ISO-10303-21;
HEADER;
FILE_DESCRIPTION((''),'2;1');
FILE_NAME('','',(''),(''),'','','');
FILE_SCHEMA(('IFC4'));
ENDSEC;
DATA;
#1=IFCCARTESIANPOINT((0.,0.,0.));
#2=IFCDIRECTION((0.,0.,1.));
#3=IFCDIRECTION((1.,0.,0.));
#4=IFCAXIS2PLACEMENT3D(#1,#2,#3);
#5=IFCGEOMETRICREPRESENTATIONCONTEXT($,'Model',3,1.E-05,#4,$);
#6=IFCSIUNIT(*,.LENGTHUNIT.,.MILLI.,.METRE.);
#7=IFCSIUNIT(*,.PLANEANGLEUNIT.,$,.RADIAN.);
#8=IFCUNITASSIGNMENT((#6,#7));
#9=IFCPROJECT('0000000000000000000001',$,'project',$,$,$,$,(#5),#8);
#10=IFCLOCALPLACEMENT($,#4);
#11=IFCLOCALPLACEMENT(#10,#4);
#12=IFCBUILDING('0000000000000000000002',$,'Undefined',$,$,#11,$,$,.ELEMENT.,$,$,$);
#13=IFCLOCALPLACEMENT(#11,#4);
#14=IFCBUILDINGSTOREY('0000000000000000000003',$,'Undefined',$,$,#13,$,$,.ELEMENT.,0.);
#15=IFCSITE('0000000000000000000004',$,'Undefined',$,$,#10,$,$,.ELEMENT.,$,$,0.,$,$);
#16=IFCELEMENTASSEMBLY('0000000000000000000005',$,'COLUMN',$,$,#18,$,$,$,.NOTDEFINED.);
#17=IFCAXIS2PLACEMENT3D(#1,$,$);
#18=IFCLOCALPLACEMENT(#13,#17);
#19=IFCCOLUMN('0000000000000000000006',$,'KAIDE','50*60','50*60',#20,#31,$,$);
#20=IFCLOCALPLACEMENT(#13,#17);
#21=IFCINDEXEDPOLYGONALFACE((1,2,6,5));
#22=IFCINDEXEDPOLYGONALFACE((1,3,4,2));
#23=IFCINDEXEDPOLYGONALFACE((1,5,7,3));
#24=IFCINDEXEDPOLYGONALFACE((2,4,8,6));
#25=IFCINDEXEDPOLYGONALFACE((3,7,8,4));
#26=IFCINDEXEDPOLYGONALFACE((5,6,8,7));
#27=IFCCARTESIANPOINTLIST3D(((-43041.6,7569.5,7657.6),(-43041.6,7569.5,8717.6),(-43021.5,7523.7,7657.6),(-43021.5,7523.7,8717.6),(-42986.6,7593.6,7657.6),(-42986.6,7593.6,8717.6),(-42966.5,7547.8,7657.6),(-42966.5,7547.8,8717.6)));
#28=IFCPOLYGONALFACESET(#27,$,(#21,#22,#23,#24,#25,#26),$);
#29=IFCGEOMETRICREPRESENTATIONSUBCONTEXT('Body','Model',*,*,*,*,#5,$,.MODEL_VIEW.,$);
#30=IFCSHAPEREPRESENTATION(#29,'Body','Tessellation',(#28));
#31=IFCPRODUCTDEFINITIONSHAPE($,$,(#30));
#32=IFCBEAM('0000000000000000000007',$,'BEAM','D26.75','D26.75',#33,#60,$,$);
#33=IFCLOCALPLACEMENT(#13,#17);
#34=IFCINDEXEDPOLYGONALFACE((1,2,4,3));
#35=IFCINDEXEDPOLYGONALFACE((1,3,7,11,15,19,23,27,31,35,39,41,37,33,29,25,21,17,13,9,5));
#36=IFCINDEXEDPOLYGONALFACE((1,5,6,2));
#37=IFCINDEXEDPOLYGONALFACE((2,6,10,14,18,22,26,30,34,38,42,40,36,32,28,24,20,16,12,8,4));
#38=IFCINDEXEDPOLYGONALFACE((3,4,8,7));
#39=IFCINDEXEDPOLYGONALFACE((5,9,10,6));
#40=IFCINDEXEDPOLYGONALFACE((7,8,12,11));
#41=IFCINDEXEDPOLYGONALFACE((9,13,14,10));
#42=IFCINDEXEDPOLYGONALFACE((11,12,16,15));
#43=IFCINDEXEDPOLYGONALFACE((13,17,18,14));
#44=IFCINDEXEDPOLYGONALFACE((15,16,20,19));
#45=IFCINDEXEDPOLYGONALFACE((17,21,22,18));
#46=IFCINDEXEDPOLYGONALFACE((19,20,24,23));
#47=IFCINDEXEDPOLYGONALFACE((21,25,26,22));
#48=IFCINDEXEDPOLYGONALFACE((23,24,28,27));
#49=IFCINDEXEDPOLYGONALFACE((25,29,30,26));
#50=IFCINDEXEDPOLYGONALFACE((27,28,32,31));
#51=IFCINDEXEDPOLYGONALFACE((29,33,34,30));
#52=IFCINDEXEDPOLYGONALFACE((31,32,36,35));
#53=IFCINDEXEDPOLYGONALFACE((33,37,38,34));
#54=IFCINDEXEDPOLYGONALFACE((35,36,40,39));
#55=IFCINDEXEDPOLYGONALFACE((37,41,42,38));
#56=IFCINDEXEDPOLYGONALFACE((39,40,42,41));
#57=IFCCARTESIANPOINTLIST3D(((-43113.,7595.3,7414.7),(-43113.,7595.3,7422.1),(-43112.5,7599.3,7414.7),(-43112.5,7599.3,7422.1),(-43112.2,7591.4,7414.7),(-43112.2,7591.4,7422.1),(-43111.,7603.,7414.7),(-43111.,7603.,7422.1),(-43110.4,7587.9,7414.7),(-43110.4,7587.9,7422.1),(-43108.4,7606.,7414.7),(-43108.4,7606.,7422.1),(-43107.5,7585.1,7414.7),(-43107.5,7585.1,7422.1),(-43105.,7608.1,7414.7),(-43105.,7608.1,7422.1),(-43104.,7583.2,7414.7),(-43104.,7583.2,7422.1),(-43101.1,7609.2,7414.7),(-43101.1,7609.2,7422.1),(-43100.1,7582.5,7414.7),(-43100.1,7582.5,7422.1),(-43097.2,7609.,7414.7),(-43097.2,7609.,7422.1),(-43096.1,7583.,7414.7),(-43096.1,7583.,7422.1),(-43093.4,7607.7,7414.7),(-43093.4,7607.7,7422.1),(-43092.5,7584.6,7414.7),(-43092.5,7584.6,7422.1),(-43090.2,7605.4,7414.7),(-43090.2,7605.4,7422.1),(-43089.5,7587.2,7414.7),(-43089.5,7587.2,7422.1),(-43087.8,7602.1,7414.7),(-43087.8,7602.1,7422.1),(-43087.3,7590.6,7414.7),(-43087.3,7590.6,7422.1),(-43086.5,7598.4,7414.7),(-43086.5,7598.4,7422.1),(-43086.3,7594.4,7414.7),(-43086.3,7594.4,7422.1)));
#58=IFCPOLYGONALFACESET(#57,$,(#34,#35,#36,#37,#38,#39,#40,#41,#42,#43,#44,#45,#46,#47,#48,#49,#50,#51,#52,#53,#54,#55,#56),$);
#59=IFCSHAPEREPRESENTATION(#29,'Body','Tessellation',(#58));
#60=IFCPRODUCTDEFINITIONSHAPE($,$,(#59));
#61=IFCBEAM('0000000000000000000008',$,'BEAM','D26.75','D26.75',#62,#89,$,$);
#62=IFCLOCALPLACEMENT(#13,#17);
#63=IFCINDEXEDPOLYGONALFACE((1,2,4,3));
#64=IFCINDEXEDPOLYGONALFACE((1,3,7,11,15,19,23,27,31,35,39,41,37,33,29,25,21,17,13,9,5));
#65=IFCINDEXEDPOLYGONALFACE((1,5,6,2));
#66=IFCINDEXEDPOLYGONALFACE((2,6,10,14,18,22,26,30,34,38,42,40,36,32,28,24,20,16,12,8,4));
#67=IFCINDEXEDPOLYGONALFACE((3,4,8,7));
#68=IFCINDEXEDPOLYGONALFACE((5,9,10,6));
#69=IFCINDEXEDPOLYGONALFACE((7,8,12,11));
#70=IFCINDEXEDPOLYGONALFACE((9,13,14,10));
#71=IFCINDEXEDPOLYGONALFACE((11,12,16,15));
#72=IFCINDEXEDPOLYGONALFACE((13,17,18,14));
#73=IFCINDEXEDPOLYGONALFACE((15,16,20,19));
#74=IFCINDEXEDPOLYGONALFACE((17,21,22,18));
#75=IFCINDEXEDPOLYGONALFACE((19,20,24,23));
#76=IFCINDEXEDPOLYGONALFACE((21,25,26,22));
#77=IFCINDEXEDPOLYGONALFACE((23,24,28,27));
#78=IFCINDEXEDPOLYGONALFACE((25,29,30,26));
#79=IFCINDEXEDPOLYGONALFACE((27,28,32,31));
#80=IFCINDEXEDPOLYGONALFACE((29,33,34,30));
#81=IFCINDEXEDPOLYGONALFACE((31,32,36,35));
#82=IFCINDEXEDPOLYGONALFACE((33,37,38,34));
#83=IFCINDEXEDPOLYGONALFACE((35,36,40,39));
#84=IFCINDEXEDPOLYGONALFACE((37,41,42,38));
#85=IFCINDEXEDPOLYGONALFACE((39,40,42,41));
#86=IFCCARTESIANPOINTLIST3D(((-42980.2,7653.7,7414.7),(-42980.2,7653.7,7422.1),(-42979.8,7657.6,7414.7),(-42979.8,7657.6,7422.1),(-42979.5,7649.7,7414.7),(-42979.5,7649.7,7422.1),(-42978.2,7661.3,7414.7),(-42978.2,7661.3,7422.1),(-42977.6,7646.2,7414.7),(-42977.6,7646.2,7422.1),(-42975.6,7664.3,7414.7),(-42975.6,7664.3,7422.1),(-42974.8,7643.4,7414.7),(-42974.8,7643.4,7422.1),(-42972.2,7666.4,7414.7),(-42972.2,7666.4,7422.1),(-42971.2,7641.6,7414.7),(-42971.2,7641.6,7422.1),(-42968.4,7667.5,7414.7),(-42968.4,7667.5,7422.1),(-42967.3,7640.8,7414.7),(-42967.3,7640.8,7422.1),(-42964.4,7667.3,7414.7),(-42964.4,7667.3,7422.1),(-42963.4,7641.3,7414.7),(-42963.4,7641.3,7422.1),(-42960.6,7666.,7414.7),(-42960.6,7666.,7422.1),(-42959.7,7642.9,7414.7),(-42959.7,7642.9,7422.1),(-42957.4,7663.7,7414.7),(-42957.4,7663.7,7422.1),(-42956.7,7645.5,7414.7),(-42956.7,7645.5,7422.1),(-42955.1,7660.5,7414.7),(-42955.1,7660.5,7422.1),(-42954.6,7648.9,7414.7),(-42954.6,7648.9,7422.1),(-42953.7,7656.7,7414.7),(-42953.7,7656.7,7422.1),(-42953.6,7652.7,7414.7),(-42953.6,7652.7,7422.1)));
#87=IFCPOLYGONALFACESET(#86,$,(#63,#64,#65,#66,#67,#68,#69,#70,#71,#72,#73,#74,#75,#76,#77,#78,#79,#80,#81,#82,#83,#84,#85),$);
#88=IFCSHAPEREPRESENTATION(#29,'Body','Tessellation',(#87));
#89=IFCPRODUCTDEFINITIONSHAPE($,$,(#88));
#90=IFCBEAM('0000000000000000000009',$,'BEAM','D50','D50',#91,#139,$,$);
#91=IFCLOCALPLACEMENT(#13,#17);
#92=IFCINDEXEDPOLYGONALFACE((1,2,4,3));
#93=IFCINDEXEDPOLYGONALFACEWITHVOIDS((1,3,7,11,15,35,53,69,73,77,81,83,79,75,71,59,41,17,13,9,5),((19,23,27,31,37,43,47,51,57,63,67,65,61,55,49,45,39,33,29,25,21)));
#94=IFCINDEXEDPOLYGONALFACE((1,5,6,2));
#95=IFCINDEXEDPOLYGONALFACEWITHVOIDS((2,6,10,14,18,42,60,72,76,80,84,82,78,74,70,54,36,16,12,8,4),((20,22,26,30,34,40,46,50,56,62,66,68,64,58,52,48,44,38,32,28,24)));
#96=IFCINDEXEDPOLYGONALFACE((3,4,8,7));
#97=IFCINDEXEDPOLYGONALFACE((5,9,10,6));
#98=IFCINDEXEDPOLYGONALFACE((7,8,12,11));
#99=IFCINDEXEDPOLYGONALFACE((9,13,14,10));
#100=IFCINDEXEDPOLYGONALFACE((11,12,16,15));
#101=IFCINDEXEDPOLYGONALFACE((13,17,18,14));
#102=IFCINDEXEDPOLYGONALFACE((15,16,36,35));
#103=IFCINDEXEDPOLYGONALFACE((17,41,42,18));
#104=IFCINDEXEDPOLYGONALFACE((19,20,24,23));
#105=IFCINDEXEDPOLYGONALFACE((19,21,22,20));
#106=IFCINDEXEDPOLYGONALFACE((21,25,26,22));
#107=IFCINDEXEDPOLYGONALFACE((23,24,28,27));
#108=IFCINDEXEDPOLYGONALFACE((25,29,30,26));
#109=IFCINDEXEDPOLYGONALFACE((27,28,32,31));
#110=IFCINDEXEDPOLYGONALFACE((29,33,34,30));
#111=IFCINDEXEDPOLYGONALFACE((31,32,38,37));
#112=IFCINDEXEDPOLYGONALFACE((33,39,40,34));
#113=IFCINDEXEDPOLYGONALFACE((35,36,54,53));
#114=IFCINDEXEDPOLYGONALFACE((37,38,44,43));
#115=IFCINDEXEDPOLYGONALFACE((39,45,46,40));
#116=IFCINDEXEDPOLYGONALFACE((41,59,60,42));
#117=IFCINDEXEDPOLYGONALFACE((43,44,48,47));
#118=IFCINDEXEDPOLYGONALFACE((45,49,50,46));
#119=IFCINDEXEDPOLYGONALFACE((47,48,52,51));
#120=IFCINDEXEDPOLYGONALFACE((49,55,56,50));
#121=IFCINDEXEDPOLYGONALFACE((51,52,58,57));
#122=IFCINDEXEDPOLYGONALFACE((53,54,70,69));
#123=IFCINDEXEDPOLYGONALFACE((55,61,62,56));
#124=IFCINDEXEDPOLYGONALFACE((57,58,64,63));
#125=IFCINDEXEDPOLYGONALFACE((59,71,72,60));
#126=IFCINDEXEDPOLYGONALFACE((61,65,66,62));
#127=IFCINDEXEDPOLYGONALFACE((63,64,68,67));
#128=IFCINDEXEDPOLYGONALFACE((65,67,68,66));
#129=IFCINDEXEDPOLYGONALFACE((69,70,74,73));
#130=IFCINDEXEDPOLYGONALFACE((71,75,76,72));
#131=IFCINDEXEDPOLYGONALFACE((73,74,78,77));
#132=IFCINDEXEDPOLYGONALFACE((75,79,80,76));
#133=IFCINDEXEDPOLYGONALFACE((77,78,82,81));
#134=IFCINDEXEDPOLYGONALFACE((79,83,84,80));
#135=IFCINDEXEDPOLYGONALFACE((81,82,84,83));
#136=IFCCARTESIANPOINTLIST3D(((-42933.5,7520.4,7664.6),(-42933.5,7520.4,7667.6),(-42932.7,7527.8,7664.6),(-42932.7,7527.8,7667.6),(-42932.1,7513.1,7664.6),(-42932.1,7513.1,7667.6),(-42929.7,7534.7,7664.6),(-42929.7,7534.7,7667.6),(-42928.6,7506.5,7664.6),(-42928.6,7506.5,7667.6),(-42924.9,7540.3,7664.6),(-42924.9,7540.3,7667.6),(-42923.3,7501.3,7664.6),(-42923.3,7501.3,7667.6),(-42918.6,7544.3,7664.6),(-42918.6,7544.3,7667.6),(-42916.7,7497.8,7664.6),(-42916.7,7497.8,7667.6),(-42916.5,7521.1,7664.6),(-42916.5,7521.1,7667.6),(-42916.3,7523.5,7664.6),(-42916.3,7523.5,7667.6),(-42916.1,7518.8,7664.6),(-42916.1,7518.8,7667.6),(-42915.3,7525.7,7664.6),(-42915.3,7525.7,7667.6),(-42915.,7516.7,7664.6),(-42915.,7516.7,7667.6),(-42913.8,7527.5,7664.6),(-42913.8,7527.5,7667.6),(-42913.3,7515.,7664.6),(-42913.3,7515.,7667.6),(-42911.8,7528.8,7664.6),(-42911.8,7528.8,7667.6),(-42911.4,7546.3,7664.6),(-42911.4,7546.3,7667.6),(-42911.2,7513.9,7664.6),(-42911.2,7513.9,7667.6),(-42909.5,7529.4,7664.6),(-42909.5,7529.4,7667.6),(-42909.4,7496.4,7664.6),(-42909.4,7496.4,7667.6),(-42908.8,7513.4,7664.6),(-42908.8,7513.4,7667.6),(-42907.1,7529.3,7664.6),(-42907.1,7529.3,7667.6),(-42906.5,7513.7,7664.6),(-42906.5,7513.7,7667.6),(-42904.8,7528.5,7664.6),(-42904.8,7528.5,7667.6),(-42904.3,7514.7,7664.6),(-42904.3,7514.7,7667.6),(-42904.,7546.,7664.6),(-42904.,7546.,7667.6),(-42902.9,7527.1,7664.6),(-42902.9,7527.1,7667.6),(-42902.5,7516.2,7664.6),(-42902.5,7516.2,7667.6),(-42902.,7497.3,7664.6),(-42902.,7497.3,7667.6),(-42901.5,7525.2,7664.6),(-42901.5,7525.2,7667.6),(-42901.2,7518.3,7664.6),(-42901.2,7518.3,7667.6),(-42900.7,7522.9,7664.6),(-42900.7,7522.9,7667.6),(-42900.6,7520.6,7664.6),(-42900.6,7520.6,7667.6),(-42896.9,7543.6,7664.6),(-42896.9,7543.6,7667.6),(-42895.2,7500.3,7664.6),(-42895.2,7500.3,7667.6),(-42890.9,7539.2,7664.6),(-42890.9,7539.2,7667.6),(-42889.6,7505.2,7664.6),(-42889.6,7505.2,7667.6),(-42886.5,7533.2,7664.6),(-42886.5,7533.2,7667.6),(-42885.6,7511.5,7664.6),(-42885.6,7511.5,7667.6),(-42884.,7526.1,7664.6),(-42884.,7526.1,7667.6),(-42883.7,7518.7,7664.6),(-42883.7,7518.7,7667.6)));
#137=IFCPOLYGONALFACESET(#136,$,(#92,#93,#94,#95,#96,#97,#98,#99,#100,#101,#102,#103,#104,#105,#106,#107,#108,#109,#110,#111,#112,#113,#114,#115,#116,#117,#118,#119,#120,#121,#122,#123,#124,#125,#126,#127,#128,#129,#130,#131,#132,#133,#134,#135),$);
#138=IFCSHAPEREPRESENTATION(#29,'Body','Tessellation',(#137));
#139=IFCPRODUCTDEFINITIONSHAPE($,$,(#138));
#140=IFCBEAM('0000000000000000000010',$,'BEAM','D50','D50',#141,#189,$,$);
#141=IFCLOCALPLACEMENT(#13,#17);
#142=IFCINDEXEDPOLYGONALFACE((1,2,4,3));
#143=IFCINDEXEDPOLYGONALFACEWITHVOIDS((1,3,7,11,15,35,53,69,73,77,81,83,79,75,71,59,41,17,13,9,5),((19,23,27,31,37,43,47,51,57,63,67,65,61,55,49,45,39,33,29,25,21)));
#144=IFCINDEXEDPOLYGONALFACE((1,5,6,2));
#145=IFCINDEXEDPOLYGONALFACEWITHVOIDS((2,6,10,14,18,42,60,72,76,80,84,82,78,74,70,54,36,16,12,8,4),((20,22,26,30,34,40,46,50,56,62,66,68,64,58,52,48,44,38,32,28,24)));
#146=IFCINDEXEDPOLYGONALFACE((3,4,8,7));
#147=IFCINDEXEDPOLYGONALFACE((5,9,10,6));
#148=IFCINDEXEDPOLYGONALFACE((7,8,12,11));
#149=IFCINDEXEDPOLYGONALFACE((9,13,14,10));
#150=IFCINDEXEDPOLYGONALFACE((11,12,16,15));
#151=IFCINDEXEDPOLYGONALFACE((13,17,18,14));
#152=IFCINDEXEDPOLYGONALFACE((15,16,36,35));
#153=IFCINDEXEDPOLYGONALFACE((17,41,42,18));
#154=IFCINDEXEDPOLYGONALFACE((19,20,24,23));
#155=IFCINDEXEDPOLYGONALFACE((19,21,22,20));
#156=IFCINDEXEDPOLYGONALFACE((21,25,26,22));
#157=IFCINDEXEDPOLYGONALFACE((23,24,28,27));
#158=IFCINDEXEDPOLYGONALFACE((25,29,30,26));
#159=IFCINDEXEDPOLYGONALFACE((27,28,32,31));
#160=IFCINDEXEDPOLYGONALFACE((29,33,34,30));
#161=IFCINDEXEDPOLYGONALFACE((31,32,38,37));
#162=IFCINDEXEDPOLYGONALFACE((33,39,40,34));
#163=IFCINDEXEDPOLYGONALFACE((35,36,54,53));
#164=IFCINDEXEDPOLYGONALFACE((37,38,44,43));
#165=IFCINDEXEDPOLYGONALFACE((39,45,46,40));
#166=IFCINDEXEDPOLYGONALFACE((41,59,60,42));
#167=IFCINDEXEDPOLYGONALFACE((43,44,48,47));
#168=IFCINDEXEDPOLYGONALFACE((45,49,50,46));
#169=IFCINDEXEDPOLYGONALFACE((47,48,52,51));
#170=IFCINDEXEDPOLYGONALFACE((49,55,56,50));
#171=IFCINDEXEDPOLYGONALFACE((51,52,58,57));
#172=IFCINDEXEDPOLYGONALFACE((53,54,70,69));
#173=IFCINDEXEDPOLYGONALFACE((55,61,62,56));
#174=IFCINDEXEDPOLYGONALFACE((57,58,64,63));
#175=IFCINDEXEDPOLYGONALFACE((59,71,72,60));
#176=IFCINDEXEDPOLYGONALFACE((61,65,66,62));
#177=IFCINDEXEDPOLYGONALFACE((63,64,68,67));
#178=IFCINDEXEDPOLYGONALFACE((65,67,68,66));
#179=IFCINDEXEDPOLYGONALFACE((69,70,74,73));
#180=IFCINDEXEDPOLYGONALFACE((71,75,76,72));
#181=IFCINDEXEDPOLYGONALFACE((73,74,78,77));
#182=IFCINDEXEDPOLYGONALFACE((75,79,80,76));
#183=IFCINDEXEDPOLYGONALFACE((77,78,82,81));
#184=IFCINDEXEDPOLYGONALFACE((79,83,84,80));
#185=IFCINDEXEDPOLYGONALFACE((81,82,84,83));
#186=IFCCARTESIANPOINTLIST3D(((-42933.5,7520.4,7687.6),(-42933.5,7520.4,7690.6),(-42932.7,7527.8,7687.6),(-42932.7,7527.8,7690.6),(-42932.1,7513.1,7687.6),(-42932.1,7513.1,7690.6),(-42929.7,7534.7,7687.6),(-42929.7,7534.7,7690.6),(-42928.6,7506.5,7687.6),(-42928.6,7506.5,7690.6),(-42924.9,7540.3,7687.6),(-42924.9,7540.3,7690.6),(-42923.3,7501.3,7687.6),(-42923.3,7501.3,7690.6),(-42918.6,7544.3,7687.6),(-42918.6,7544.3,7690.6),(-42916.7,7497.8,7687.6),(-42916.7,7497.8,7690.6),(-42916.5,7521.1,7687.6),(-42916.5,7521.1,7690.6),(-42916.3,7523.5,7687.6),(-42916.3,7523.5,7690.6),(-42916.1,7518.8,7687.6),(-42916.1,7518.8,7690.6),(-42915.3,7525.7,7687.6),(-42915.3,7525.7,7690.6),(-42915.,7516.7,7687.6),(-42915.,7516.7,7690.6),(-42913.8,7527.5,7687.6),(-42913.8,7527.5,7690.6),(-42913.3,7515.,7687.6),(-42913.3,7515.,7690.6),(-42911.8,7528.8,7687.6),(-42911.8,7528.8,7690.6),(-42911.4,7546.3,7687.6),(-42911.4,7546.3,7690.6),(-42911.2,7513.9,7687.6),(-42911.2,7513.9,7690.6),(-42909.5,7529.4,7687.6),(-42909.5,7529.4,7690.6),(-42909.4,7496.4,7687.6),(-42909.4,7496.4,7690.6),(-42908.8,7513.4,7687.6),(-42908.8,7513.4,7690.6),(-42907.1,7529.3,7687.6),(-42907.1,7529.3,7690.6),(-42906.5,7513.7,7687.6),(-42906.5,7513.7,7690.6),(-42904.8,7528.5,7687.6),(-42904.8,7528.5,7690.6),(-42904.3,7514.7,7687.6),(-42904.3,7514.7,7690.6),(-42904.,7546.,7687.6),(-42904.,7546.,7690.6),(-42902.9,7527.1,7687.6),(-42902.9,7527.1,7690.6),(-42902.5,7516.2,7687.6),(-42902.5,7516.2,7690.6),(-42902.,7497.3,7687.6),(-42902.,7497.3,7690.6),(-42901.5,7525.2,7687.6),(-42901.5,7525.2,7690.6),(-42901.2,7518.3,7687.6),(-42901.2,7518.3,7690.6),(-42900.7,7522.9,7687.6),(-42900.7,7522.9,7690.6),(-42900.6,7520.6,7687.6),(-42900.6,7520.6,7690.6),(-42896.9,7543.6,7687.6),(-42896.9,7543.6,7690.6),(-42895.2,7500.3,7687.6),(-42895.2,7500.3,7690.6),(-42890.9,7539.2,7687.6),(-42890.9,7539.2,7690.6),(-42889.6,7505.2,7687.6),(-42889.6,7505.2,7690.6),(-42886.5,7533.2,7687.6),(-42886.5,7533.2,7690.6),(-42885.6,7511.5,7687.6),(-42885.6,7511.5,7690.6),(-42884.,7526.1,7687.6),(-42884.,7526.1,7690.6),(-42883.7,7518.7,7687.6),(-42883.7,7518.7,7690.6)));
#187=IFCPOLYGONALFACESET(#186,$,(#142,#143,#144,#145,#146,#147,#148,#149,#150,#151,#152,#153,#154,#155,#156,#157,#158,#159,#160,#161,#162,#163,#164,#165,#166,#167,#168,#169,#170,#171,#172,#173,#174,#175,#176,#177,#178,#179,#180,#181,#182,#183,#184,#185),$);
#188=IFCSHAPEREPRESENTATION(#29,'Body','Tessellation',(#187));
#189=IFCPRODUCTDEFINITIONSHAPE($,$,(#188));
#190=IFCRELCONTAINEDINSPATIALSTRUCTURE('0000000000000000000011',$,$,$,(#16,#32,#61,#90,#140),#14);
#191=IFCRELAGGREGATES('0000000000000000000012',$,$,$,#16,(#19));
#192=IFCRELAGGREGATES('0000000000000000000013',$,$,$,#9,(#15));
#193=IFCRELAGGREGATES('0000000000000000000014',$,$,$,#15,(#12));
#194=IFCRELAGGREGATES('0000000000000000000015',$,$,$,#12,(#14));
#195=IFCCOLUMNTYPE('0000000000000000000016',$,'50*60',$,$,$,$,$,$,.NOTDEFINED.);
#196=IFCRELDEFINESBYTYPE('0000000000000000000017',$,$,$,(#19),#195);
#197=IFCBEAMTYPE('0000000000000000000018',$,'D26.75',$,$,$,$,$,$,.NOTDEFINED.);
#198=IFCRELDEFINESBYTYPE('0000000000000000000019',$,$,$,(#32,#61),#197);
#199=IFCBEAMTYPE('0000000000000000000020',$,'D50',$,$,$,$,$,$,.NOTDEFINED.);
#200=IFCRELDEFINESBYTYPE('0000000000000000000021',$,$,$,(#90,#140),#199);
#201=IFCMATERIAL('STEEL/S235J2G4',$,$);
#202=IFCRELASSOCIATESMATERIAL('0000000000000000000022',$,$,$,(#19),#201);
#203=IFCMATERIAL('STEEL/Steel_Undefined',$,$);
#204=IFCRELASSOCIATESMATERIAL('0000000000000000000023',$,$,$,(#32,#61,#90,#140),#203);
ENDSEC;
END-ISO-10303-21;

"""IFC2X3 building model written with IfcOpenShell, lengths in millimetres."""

from ifc_helpers import new_model, si_unit, frame, origin_with_axes, origin_2d_with_axis, place, context, subcontext, project, spatial, rectangle, circle, extrude, material, type_object, element, aggregate, save


model = new_model("IFC2X3")

# Units and contexts
model_context = context("Model", 3, precision=1e-05, world=origin_with_axes())
body_context = subcontext(model_context, "Body", "Model", "MODEL_VIEW")
ifc_project = project(units=[si_unit("LENGTHUNIT", "METRE", prefix="MILLI"), si_unit("PLANEANGLEUNIT", "RADIAN")], contexts=[model_context])

# Site, building, storey
site_placement = place(None, origin_with_axes())
site = spatial("IfcSite", under=ifc_project, at=site_placement, Name="Undefined", CompositionType="ELEMENT", RefElevation=0.0)
building_placement = place(site_placement, origin_with_axes())
building = spatial("IfcBuilding", under=site, at=building_placement, Name="Undefined", CompositionType="ELEMENT")
storey_placement = place(building_placement, origin_with_axes())
storey = spatial("IfcBuildingStorey", under=building, at=storey_placement, Name="Undefined", CompositionType="ELEMENT", Elevation=0.0)

# Element assembly, column
assembly_placement = place(storey_placement, frame((-43004.0, 7558.7, 7657.6), z_axis=(-0.402198, 0.915553, 0.0), x_axis=(0.0, 0.0, 1.0)))
assembly = element("IfcElementAssembly", 1, at=assembly_placement, inside=storey, Name="COLUMN", PredefinedType="NOTDEFINED")
ifc_material_1 = material(Name="STEEL/S235J2G4")
column_type = type_object("IfcColumnType", Name="50*60", PredefinedType="NOTDEFINED")
column_placement = place(storey_placement, frame((-43004.0, 7558.7, 7657.6), z_axis=(0.0, 0.0, 1.0), x_axis=(1.0, 0.0, 0.0)))
column = element("IfcColumn", 2, at=column_placement, type_object=column_type, material=ifc_material_1, Name="KAIDE", Description="50*60", ObjectType="50*60", context=body_context, shape_type="SweptSolid", body=[
    extrude(rectangle(XDim=60.0, YDim=50.0, at=origin_2d_with_axis()), frame((0.0, 0.0, 1060.0), z_axis=(0.0, 0.0, -1.0), x_axis=(-0.915553, -0.402197, 0.0)), (0.0, 0.0, 1.0), 1060.0),
])
aggregate(assembly, [column])

# Shared definitions
ifc_material_2 = material(Name="STEEL/Steel_Undefined")
beam_type_1 = type_object("IfcBeamType", Name="D26.75", PredefinedType="NOTDEFINED")

# Beam
beam_1_placement = place(storey_placement, frame((-43099.6, 7595.9, 7422.1), z_axis=(-0.915553, -0.402198, 0.0), x_axis=(0.0, 0.0, -1.0)))
element("IfcBeam", 3, at=beam_1_placement, inside=storey, type_object=beam_type_1, material=ifc_material_2, Name="BEAM", Description="D26.75", ObjectType="D26.75", context=body_context, shape_type="SweptSolid", body=[
    extrude(circle(Radius=13.4, at=origin_2d_with_axis()), frame((7.4, 0.0, 0.0), z_axis=(-1.0, 0.0, 0.0), x_axis=(0.0, -1.0, 0.0)), (0.0, 0.0, 1.0), 7.4),
])

# Beam
beam_2_placement = place(storey_placement, frame((-42966.9, 7654.2, 7422.1), z_axis=(-0.915553, -0.402198, 0.0), x_axis=(0.0, 0.0, -1.0)))
element("IfcBeam", 4, at=beam_2_placement, inside=storey, type_object=beam_type_1, material=ifc_material_2, Name="BEAM", Description="D26.75", ObjectType="D26.75", context=body_context, shape_type="SweptSolid", body=[
    extrude(circle(Radius=13.4, at=origin_2d_with_axis()), frame((7.4, 0.0, 0.0), z_axis=(-1.0, 0.0, 0.0), x_axis=(0.0, -1.0, 0.0)), (0.0, 0.0, 1.0), 7.4),
])

# Beams, openings
beam_type_2 = type_object("IfcBeamType", Name="D50", PredefinedType="NOTDEFINED")
beam_3_placement = place(storey_placement, frame((-42908.5, 7521.4, 7667.6), z_axis=(-0.915553, -0.402198, 0.0), x_axis=(0.0, 0.0, -1.0)))
beam_3 = element("IfcBeam", 5, at=beam_3_placement, inside=storey, type_object=beam_type_2, material=ifc_material_2, Name="BEAM", Description="D50", ObjectType="D50", context=body_context, shape_type="SweptSolid", body=[
    extrude(circle(Radius=25.0, at=origin_2d_with_axis()), frame((3.0, 0.0, 0.0), z_axis=(-1.0, 0.0, 0.0), x_axis=(0.0, -1.0, 0.0)), (0.0, 0.0, 1.0), 3.0),
])
opening_1_placement = place(storey_placement, frame((-42908.5, 7521.4, 7667.6), z_axis=(-0.915553, -0.402198, 0.0), x_axis=(0.0, 0.0, -1.0)))
element("IfcOpeningElement", 6, at=opening_1_placement, cuts=beam_3, ObjectType="Recess", context=body_context, shape_type="SweptSolid", body=[
    extrude(circle(Radius=8.0, at=origin_2d_with_axis()), frame((245.5, 0.0, 0.0), z_axis=(-1.0, 0.0, 0.0), x_axis=(0.0, -1.0, 0.0)), (0.0, 0.0, 1.0), 292.6),
])
beam_4_placement = place(storey_placement, frame((-42908.5, 7521.4, 7690.6), z_axis=(-0.915553, -0.402198, 0.0), x_axis=(0.0, 0.0, -1.0)))
beam_4 = element("IfcBeam", 7, at=beam_4_placement, inside=storey, type_object=beam_type_2, material=ifc_material_2, Name="BEAM", Description="D50", ObjectType="D50", context=body_context, shape_type="SweptSolid", body=[
    extrude(circle(Radius=25.0, at=origin_2d_with_axis()), frame((3.0, 0.0, 0.0), z_axis=(-1.0, 0.0, 0.0), x_axis=(0.0, -1.0, 0.0)), (0.0, 0.0, 1.0), 3.0),
])
opening_2_placement = place(storey_placement, frame((-42908.5, 7521.4, 7690.6), z_axis=(-0.915553, -0.402198, 0.0), x_axis=(0.0, 0.0, -1.0)))
element("IfcOpeningElement", 8, at=opening_2_placement, cuts=beam_4, ObjectType="Recess", context=body_context, shape_type="SweptSolid", body=[
    extrude(circle(Radius=8.0, at=origin_2d_with_axis()), frame((268.5, 0.0, 0.0), z_axis=(-1.0, 0.0, 0.0), x_axis=(0.0, -1.0, 0.0)), (0.0, 0.0, 1.0), 292.6),
])

save(model, "model.ifc")
